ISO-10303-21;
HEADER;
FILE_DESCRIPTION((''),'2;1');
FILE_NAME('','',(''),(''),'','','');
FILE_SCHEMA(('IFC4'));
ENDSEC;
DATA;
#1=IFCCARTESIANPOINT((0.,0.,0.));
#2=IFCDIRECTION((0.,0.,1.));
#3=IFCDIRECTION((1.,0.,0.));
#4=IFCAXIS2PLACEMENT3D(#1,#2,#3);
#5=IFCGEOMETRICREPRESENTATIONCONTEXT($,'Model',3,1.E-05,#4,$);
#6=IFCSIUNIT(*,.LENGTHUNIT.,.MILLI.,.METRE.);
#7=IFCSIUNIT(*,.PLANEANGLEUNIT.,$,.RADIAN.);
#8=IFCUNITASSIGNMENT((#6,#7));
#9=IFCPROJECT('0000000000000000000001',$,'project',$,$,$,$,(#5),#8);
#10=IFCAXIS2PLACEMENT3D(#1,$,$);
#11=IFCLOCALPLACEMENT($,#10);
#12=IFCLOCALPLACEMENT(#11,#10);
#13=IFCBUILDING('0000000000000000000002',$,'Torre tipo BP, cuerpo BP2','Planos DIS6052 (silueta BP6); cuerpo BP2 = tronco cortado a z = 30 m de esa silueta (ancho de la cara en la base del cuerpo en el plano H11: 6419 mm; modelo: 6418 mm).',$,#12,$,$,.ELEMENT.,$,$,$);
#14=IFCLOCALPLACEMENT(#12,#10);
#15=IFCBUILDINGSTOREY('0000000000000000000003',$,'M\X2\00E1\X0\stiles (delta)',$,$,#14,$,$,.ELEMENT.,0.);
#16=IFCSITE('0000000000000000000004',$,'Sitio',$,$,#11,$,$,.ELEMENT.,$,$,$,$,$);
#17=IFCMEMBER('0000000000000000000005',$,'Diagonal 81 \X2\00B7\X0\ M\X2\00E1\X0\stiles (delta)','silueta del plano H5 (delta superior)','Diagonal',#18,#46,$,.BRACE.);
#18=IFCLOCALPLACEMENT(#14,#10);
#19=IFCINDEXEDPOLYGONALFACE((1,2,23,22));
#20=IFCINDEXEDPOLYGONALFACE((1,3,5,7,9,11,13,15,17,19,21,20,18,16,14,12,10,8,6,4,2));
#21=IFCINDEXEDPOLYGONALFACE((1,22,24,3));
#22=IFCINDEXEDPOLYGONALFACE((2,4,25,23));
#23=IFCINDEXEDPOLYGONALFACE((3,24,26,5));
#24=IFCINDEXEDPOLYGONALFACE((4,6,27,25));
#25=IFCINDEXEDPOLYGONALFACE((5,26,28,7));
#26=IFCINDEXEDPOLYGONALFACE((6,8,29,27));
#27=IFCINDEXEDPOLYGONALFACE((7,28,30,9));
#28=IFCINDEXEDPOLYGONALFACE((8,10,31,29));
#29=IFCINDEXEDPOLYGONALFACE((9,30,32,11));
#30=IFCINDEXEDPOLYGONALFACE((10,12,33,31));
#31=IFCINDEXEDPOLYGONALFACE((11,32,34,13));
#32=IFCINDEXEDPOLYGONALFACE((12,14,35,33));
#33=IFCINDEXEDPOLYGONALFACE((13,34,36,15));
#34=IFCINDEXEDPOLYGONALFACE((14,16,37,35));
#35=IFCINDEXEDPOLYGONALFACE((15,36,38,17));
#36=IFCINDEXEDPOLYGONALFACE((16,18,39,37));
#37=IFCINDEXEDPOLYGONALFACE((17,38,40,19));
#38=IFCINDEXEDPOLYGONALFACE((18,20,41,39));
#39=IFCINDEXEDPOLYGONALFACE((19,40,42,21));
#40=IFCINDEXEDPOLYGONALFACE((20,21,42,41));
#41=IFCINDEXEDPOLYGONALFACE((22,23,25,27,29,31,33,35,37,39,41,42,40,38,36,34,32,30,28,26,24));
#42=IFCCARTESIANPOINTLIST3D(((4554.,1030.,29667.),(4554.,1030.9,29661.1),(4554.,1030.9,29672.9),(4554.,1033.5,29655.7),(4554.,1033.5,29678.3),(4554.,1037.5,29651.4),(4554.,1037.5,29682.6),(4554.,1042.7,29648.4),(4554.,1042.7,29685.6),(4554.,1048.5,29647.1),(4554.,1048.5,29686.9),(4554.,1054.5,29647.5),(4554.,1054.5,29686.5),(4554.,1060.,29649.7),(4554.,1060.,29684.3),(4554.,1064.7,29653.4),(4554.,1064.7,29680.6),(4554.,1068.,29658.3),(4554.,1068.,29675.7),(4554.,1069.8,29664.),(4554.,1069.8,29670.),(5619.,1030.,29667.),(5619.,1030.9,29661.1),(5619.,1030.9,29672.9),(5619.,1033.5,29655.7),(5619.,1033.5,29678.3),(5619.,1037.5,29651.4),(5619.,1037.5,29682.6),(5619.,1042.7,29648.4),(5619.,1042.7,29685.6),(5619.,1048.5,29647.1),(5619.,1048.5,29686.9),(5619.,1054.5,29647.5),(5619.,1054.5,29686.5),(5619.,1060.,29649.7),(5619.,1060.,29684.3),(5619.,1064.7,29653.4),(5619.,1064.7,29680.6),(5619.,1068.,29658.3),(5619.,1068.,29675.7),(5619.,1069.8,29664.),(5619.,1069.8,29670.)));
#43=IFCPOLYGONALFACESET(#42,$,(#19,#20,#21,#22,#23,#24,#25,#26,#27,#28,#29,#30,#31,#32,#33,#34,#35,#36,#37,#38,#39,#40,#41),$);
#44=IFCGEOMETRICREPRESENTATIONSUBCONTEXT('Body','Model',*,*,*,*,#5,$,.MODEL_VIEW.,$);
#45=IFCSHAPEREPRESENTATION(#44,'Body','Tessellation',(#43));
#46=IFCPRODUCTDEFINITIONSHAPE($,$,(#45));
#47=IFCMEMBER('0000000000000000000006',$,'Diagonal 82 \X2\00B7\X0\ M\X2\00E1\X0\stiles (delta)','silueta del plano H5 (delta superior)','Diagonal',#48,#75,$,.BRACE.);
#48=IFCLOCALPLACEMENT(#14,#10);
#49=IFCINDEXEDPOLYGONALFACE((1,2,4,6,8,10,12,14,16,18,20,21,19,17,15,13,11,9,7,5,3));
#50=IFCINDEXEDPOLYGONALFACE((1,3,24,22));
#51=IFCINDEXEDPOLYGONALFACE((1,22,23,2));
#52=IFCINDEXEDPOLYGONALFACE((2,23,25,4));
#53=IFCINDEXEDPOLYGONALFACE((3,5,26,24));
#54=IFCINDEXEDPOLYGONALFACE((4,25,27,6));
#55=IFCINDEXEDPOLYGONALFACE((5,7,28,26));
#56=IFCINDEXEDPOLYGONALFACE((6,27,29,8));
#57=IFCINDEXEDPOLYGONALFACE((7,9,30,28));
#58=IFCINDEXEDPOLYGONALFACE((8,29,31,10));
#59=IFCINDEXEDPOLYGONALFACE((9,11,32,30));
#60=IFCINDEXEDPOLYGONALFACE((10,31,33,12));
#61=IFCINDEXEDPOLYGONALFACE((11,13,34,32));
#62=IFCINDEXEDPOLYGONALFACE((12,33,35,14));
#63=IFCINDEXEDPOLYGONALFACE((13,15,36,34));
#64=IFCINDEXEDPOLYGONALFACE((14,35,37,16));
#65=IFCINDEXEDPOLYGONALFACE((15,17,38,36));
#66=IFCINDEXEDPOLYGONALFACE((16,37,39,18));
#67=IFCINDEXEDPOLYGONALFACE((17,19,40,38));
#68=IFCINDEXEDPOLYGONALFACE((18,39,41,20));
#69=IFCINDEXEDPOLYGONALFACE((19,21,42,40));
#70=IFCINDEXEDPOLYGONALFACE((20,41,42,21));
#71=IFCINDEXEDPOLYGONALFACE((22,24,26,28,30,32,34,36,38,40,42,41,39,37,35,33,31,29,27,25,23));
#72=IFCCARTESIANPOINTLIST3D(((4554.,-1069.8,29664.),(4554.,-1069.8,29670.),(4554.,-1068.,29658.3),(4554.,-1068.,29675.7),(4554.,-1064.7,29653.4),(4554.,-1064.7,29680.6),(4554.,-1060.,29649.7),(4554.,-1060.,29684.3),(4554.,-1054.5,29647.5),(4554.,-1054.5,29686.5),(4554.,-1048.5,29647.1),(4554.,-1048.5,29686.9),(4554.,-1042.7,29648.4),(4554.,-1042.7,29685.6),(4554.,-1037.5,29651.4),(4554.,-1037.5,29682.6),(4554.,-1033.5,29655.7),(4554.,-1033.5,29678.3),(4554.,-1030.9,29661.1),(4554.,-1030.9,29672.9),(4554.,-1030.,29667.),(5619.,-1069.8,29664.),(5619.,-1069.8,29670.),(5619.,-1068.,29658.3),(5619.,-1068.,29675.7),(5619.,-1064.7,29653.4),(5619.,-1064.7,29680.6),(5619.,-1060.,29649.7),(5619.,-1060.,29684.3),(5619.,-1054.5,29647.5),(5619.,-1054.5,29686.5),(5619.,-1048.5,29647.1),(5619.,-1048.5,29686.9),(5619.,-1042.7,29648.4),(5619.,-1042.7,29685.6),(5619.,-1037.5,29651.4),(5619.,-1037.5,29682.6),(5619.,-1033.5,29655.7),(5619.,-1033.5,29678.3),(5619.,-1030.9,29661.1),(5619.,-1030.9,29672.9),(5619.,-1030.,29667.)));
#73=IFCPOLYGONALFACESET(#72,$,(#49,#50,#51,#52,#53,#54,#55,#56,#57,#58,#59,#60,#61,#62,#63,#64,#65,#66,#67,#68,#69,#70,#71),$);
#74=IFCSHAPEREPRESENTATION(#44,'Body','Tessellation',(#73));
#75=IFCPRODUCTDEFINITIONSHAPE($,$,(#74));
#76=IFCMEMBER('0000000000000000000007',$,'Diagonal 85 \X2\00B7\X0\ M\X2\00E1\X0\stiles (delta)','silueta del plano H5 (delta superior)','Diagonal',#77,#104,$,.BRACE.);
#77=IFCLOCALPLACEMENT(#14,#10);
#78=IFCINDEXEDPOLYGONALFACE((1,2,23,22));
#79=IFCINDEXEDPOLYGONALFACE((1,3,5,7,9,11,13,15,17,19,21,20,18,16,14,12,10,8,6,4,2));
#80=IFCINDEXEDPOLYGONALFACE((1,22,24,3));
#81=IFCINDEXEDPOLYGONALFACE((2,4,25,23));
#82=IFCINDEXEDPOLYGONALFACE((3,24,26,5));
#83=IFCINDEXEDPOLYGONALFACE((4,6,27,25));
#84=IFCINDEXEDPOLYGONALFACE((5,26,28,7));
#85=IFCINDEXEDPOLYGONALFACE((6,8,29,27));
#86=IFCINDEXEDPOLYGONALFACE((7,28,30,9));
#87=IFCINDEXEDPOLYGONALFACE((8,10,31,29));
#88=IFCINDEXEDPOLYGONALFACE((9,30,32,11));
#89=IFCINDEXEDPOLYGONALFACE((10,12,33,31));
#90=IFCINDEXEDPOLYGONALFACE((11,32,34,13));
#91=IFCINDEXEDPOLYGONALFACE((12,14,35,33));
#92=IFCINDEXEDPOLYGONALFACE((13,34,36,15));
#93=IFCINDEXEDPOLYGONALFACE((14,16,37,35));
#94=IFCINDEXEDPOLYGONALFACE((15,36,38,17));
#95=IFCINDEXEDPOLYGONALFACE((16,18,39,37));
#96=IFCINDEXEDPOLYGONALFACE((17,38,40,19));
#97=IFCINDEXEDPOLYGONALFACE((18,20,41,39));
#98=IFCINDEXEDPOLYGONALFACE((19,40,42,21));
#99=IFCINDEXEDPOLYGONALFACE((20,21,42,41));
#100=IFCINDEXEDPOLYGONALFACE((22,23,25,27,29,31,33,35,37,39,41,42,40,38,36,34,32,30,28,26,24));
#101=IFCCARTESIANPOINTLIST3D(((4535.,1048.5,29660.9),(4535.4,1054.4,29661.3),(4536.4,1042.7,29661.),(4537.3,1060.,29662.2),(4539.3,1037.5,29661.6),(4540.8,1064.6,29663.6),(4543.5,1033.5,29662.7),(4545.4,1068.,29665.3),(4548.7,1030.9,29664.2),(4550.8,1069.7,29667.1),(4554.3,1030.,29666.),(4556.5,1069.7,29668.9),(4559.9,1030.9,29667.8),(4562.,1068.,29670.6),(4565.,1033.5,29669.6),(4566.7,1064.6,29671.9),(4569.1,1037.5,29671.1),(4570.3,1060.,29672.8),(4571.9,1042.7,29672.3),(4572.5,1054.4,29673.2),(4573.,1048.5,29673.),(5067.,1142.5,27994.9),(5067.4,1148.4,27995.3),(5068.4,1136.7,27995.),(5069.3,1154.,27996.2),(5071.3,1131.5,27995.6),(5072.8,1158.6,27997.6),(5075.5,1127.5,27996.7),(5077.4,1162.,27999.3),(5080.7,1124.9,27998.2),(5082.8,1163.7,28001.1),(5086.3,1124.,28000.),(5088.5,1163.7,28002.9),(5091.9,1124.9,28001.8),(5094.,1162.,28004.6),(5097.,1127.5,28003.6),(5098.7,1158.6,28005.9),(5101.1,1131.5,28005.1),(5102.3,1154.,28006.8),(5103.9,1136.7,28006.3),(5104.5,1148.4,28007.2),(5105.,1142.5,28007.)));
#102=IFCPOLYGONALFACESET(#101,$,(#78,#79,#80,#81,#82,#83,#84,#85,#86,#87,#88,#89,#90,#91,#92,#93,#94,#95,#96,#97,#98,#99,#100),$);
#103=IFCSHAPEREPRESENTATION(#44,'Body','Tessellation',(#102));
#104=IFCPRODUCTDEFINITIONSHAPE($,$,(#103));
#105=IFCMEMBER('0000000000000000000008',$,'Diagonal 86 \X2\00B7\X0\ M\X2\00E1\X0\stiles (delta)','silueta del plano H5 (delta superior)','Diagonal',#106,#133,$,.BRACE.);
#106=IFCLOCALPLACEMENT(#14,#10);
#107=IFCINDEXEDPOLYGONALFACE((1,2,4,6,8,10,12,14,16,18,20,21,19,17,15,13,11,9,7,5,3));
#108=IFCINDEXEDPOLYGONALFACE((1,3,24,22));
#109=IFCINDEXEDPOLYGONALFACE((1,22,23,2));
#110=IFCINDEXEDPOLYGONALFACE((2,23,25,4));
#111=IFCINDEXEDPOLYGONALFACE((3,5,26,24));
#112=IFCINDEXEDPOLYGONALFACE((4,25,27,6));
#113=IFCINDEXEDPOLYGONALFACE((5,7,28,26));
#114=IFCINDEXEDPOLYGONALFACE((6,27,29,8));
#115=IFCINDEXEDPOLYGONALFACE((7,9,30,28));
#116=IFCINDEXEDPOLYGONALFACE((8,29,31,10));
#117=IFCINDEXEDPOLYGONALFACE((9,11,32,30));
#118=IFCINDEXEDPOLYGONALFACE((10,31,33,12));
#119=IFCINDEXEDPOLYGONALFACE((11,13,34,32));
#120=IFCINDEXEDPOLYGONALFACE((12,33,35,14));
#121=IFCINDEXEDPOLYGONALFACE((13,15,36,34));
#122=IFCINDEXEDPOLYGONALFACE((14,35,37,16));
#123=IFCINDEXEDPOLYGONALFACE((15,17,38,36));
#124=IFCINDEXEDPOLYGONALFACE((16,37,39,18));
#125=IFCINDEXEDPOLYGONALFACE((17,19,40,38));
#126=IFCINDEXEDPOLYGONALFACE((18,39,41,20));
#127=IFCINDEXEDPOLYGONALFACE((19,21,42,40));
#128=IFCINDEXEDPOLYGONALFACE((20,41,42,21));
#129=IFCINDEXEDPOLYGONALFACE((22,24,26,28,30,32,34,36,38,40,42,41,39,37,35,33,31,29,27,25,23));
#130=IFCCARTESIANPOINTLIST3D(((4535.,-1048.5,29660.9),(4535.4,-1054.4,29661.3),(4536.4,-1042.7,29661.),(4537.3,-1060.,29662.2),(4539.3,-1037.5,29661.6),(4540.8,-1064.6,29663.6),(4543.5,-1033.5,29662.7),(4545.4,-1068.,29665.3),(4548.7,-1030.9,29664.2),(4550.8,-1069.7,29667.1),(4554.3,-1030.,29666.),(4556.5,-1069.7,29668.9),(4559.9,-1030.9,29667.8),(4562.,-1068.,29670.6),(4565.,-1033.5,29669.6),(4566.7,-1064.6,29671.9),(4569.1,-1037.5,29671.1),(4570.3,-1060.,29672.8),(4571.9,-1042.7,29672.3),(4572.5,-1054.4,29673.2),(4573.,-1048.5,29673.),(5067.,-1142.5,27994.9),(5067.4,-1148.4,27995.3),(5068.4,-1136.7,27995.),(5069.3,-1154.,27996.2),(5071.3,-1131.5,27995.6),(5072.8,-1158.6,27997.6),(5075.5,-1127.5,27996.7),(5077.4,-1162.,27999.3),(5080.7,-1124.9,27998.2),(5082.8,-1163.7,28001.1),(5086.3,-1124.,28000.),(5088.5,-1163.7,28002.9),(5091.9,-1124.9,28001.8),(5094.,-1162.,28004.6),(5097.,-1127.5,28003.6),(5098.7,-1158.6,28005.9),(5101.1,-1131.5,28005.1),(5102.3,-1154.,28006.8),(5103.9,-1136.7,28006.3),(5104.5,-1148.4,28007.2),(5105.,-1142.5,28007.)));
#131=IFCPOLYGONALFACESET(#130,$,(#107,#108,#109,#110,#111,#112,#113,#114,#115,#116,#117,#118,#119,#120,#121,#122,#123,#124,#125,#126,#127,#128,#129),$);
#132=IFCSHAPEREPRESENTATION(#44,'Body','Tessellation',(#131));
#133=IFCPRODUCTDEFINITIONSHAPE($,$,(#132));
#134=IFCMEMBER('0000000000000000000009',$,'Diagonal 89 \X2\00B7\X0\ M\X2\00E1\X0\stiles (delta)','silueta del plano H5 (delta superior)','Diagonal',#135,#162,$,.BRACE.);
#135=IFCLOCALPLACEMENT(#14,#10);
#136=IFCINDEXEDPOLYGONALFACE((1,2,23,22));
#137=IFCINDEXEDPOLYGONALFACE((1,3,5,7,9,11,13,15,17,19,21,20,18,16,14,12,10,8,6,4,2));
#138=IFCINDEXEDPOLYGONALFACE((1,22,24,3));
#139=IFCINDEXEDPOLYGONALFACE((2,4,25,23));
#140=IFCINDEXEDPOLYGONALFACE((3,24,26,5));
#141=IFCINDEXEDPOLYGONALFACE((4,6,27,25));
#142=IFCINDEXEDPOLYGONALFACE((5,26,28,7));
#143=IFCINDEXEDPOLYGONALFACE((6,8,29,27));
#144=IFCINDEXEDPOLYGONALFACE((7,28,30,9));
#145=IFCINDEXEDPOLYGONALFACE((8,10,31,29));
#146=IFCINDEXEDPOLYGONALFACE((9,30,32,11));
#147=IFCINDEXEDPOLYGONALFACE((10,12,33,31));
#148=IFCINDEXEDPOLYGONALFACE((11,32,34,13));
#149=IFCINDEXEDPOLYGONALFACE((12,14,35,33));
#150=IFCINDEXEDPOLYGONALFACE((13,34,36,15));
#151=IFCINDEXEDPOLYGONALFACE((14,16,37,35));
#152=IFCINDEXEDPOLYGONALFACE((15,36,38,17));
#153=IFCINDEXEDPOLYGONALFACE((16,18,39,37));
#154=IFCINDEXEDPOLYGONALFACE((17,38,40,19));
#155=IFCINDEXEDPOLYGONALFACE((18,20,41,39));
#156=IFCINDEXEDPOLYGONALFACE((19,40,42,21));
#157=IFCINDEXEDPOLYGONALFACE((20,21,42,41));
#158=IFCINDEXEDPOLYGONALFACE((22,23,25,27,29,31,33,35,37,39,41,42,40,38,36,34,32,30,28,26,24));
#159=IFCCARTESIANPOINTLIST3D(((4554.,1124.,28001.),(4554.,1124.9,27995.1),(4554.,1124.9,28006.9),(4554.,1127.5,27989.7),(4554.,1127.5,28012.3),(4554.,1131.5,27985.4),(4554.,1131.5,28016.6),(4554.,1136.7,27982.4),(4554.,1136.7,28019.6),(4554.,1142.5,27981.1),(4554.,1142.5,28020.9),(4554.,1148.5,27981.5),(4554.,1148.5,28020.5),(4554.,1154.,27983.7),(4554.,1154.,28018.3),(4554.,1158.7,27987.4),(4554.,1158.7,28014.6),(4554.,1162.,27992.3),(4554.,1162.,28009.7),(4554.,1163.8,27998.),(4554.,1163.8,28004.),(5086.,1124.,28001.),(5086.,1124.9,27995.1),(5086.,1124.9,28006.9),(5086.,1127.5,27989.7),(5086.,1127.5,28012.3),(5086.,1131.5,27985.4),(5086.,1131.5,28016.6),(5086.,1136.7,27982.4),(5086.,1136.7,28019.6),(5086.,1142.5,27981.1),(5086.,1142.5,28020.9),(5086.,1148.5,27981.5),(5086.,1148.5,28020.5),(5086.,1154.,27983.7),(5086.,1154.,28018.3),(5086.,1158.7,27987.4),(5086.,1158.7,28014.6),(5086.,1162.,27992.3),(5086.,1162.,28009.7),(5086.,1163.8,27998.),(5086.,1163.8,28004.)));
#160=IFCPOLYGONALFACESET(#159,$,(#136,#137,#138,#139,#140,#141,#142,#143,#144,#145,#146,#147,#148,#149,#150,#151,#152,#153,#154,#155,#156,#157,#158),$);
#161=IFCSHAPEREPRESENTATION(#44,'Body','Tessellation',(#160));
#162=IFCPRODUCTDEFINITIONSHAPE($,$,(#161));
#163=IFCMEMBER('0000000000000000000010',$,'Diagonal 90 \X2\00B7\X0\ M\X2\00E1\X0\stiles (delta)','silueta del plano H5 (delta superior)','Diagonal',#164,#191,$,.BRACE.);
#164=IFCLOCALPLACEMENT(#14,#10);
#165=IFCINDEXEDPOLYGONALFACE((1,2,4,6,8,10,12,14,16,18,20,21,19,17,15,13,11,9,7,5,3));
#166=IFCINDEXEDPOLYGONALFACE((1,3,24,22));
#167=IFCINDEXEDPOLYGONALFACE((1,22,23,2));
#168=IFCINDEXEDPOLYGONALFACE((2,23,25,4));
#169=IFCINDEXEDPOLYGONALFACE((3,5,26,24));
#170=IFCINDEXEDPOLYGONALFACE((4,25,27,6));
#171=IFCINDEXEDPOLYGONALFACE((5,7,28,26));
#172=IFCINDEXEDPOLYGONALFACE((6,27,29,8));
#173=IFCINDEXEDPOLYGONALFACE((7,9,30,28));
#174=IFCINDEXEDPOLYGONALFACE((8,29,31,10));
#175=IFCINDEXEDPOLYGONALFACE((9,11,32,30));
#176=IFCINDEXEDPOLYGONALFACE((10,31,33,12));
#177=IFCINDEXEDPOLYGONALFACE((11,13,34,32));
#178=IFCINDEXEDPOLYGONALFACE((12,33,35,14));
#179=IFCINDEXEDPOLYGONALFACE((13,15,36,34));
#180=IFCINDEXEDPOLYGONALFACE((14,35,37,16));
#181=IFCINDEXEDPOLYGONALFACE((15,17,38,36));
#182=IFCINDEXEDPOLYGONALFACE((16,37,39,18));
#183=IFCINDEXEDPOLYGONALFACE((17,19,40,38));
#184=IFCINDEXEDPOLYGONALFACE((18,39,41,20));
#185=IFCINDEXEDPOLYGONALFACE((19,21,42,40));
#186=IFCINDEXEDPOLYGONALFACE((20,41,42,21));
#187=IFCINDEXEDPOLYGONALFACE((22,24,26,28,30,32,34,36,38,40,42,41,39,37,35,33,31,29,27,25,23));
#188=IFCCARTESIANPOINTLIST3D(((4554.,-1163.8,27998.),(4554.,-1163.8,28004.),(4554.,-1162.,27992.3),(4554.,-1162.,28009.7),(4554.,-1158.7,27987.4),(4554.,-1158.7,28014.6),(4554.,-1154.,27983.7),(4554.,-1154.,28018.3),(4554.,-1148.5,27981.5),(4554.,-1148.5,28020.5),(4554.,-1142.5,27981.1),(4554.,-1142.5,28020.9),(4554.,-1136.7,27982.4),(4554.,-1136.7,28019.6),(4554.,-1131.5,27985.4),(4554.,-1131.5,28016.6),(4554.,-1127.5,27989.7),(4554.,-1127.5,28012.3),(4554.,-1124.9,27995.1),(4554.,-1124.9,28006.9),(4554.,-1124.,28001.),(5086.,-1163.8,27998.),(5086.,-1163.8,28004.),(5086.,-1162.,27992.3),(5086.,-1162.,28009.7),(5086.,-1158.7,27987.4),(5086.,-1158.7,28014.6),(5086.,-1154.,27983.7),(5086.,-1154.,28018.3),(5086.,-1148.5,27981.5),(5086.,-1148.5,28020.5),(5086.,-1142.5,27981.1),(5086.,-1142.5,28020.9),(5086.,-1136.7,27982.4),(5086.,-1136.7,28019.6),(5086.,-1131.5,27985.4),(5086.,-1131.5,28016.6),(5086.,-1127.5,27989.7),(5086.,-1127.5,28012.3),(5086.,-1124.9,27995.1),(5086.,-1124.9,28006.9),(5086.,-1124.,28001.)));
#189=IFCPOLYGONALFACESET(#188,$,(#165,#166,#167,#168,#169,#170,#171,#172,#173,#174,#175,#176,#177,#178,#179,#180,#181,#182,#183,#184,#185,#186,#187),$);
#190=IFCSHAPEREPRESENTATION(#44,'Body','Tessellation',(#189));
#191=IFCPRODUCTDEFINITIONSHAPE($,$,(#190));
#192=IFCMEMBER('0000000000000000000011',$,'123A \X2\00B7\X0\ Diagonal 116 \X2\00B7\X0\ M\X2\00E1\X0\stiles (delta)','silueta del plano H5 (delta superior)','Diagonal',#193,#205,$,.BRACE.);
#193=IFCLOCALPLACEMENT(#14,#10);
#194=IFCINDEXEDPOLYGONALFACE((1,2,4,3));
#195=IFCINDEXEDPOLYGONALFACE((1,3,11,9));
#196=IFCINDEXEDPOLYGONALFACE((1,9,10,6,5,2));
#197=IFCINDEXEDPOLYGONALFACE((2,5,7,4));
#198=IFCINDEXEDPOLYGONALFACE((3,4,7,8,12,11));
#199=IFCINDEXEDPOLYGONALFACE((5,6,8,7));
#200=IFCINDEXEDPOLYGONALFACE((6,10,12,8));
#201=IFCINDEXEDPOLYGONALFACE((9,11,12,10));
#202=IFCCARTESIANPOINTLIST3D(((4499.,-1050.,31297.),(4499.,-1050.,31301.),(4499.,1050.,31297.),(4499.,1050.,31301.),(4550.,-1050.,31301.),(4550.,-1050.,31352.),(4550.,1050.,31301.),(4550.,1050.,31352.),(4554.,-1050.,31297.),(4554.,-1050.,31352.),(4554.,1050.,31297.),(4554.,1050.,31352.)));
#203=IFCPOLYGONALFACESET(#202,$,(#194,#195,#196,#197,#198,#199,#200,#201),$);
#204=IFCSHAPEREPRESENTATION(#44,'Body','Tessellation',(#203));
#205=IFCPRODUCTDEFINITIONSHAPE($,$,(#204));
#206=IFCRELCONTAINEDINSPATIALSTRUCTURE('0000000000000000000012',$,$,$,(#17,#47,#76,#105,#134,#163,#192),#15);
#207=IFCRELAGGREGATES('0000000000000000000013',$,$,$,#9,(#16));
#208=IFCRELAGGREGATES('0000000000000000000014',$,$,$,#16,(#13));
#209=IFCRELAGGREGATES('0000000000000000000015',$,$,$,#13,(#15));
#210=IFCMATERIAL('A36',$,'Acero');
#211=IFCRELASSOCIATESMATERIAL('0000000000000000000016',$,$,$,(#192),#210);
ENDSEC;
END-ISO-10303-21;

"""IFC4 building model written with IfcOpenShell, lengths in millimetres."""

from ifc_helpers import new_model, si_unit, frame, frame_2d, origin, origin_with_axes, place, context, subcontext, project, spatial, circle, l_section, extrude, material, element, save


model = new_model("IFC4")

# Units and contexts
model_context = context("Model", 3, precision=1e-05, world=origin_with_axes())
body_context = subcontext(model_context, "Body", "Model", "MODEL_VIEW")
ifc_project = project(units=[si_unit("LENGTHUNIT", "METRE", prefix="MILLI"), si_unit("PLANEANGLEUNIT", "RADIAN")], contexts=[model_context])

# Site, building, storey
site_placement = place(None, origin())
site = spatial("IfcSite", under=ifc_project, at=site_placement, Name="Sitio", CompositionType="ELEMENT")
building_placement = place(site_placement, origin())
building = spatial("IfcBuilding", under=site, at=building_placement, Name="Torre tipo BP, cuerpo BP2", Description="Planos DIS6052 (silueta BP6); cuerpo BP2 = tronco cortado a z = 30 m de esa silueta (ancho de la cara en la base del cuerpo en el plano H11: 6419 mm; modelo: 6418 mm).", CompositionType="ELEMENT")
storey_placement = place(building_placement, origin())
storey = spatial("IfcBuildingStorey", under=building, at=storey_placement, Name="Mástiles (delta)", CompositionType="ELEMENT", Elevation=0.0)

# Members
for number, where, z_axis, x_axis, name in (
    (1, (4554.0, 1050.0, 29667.0), (1.0, 0.0, 0.0), (0.0, -1.0, 0.0), "Diagonal 81 · Mástiles (delta)"),
    (2, (4554.0, -1050.0, 29667.0), (1.0, 0.0, 0.0), (0.0, 1.0, 0.0), "Diagonal 82 · Mástiles (delta)"),
):
    element("IfcMember", number, at=place(storey_placement, frame(where, z_axis=z_axis, x_axis=x_axis)), inside=storey, Name=name, Description="silueta del plano H5 (delta superior)", ObjectType="Diagonal", PredefinedType="BRACE", context=body_context, shape_type="SweptSolid", body=[
        extrude(circle(Radius=20.0), None, (0.0, 0.0, 1.0), 1065.0),
    ])
for number, where, z_axis, x_axis, name in (
    (3, (4554.0, 1050.0, 29667.0), (0.303756, 0.053671, -0.951237), (0.016327, -0.998559, -0.051128), "Diagonal 85 · Mástiles (delta)"),
    (4, (4554.0, -1050.0, 29667.0), (0.303756, -0.053671, -0.951237), (0.016327, 0.998559, -0.051128), "Diagonal 86 · Mástiles (delta)"),
):
    element("IfcMember", number, at=place(storey_placement, frame(where, z_axis=z_axis, x_axis=x_axis)), inside=storey, Name=name, Description="silueta del plano H5 (delta superior)", ObjectType="Diagonal", PredefinedType="BRACE", context=body_context, shape_type="SweptSolid", body=[
        extrude(circle(Radius=20.0), None, (0.0, 0.0, 1.0), 1751.4),
    ])
for number, where, z_axis, x_axis, name in (
    (5, (4554.0, 1144.0, 28001.0), (1.0, 0.0, 0.0), (0.0, -1.0, 0.0), "Diagonal 89 · Mástiles (delta)"),
    (6, (4554.0, -1144.0, 28001.0), (1.0, 0.0, 0.0), (0.0, 1.0, 0.0), "Diagonal 90 · Mástiles (delta)"),
):
    element("IfcMember", number, at=place(storey_placement, frame(where, z_axis=z_axis, x_axis=x_axis)), inside=storey, Name=name, Description="silueta del plano H5 (delta superior)", ObjectType="Diagonal", PredefinedType="BRACE", context=body_context, shape_type="SweptSolid", body=[
        extrude(circle(Radius=20.0), None, (0.0, 0.0, 1.0), 532.0),
    ])
ifc_material_1 = material(Name="A36", Category="Acero")
member_1_placement = place(storey_placement, frame((4554.0, -1050.0, 31297.0), z_axis=(0.0, 1.0, 0.0), x_axis=(-1.0, 0.0, 0.0)))
element("IfcMember", 7, at=member_1_placement, inside=storey, material=ifc_material_1, Name="123A · Diagonal 116 · Mástiles (delta)", Description="silueta del plano H5 (delta superior)", ObjectType="Diagonal", PredefinedType="BRACE", context=body_context, shape_type="SweptSolid", body=[
    extrude(l_section(Depth=55.0, Width=55.0, Thickness=4.0, at=frame_2d((27.5, 27.5))), None, (0.0, 0.0, 1.0), 2100.0),
])

save(model, "model.ifc")
